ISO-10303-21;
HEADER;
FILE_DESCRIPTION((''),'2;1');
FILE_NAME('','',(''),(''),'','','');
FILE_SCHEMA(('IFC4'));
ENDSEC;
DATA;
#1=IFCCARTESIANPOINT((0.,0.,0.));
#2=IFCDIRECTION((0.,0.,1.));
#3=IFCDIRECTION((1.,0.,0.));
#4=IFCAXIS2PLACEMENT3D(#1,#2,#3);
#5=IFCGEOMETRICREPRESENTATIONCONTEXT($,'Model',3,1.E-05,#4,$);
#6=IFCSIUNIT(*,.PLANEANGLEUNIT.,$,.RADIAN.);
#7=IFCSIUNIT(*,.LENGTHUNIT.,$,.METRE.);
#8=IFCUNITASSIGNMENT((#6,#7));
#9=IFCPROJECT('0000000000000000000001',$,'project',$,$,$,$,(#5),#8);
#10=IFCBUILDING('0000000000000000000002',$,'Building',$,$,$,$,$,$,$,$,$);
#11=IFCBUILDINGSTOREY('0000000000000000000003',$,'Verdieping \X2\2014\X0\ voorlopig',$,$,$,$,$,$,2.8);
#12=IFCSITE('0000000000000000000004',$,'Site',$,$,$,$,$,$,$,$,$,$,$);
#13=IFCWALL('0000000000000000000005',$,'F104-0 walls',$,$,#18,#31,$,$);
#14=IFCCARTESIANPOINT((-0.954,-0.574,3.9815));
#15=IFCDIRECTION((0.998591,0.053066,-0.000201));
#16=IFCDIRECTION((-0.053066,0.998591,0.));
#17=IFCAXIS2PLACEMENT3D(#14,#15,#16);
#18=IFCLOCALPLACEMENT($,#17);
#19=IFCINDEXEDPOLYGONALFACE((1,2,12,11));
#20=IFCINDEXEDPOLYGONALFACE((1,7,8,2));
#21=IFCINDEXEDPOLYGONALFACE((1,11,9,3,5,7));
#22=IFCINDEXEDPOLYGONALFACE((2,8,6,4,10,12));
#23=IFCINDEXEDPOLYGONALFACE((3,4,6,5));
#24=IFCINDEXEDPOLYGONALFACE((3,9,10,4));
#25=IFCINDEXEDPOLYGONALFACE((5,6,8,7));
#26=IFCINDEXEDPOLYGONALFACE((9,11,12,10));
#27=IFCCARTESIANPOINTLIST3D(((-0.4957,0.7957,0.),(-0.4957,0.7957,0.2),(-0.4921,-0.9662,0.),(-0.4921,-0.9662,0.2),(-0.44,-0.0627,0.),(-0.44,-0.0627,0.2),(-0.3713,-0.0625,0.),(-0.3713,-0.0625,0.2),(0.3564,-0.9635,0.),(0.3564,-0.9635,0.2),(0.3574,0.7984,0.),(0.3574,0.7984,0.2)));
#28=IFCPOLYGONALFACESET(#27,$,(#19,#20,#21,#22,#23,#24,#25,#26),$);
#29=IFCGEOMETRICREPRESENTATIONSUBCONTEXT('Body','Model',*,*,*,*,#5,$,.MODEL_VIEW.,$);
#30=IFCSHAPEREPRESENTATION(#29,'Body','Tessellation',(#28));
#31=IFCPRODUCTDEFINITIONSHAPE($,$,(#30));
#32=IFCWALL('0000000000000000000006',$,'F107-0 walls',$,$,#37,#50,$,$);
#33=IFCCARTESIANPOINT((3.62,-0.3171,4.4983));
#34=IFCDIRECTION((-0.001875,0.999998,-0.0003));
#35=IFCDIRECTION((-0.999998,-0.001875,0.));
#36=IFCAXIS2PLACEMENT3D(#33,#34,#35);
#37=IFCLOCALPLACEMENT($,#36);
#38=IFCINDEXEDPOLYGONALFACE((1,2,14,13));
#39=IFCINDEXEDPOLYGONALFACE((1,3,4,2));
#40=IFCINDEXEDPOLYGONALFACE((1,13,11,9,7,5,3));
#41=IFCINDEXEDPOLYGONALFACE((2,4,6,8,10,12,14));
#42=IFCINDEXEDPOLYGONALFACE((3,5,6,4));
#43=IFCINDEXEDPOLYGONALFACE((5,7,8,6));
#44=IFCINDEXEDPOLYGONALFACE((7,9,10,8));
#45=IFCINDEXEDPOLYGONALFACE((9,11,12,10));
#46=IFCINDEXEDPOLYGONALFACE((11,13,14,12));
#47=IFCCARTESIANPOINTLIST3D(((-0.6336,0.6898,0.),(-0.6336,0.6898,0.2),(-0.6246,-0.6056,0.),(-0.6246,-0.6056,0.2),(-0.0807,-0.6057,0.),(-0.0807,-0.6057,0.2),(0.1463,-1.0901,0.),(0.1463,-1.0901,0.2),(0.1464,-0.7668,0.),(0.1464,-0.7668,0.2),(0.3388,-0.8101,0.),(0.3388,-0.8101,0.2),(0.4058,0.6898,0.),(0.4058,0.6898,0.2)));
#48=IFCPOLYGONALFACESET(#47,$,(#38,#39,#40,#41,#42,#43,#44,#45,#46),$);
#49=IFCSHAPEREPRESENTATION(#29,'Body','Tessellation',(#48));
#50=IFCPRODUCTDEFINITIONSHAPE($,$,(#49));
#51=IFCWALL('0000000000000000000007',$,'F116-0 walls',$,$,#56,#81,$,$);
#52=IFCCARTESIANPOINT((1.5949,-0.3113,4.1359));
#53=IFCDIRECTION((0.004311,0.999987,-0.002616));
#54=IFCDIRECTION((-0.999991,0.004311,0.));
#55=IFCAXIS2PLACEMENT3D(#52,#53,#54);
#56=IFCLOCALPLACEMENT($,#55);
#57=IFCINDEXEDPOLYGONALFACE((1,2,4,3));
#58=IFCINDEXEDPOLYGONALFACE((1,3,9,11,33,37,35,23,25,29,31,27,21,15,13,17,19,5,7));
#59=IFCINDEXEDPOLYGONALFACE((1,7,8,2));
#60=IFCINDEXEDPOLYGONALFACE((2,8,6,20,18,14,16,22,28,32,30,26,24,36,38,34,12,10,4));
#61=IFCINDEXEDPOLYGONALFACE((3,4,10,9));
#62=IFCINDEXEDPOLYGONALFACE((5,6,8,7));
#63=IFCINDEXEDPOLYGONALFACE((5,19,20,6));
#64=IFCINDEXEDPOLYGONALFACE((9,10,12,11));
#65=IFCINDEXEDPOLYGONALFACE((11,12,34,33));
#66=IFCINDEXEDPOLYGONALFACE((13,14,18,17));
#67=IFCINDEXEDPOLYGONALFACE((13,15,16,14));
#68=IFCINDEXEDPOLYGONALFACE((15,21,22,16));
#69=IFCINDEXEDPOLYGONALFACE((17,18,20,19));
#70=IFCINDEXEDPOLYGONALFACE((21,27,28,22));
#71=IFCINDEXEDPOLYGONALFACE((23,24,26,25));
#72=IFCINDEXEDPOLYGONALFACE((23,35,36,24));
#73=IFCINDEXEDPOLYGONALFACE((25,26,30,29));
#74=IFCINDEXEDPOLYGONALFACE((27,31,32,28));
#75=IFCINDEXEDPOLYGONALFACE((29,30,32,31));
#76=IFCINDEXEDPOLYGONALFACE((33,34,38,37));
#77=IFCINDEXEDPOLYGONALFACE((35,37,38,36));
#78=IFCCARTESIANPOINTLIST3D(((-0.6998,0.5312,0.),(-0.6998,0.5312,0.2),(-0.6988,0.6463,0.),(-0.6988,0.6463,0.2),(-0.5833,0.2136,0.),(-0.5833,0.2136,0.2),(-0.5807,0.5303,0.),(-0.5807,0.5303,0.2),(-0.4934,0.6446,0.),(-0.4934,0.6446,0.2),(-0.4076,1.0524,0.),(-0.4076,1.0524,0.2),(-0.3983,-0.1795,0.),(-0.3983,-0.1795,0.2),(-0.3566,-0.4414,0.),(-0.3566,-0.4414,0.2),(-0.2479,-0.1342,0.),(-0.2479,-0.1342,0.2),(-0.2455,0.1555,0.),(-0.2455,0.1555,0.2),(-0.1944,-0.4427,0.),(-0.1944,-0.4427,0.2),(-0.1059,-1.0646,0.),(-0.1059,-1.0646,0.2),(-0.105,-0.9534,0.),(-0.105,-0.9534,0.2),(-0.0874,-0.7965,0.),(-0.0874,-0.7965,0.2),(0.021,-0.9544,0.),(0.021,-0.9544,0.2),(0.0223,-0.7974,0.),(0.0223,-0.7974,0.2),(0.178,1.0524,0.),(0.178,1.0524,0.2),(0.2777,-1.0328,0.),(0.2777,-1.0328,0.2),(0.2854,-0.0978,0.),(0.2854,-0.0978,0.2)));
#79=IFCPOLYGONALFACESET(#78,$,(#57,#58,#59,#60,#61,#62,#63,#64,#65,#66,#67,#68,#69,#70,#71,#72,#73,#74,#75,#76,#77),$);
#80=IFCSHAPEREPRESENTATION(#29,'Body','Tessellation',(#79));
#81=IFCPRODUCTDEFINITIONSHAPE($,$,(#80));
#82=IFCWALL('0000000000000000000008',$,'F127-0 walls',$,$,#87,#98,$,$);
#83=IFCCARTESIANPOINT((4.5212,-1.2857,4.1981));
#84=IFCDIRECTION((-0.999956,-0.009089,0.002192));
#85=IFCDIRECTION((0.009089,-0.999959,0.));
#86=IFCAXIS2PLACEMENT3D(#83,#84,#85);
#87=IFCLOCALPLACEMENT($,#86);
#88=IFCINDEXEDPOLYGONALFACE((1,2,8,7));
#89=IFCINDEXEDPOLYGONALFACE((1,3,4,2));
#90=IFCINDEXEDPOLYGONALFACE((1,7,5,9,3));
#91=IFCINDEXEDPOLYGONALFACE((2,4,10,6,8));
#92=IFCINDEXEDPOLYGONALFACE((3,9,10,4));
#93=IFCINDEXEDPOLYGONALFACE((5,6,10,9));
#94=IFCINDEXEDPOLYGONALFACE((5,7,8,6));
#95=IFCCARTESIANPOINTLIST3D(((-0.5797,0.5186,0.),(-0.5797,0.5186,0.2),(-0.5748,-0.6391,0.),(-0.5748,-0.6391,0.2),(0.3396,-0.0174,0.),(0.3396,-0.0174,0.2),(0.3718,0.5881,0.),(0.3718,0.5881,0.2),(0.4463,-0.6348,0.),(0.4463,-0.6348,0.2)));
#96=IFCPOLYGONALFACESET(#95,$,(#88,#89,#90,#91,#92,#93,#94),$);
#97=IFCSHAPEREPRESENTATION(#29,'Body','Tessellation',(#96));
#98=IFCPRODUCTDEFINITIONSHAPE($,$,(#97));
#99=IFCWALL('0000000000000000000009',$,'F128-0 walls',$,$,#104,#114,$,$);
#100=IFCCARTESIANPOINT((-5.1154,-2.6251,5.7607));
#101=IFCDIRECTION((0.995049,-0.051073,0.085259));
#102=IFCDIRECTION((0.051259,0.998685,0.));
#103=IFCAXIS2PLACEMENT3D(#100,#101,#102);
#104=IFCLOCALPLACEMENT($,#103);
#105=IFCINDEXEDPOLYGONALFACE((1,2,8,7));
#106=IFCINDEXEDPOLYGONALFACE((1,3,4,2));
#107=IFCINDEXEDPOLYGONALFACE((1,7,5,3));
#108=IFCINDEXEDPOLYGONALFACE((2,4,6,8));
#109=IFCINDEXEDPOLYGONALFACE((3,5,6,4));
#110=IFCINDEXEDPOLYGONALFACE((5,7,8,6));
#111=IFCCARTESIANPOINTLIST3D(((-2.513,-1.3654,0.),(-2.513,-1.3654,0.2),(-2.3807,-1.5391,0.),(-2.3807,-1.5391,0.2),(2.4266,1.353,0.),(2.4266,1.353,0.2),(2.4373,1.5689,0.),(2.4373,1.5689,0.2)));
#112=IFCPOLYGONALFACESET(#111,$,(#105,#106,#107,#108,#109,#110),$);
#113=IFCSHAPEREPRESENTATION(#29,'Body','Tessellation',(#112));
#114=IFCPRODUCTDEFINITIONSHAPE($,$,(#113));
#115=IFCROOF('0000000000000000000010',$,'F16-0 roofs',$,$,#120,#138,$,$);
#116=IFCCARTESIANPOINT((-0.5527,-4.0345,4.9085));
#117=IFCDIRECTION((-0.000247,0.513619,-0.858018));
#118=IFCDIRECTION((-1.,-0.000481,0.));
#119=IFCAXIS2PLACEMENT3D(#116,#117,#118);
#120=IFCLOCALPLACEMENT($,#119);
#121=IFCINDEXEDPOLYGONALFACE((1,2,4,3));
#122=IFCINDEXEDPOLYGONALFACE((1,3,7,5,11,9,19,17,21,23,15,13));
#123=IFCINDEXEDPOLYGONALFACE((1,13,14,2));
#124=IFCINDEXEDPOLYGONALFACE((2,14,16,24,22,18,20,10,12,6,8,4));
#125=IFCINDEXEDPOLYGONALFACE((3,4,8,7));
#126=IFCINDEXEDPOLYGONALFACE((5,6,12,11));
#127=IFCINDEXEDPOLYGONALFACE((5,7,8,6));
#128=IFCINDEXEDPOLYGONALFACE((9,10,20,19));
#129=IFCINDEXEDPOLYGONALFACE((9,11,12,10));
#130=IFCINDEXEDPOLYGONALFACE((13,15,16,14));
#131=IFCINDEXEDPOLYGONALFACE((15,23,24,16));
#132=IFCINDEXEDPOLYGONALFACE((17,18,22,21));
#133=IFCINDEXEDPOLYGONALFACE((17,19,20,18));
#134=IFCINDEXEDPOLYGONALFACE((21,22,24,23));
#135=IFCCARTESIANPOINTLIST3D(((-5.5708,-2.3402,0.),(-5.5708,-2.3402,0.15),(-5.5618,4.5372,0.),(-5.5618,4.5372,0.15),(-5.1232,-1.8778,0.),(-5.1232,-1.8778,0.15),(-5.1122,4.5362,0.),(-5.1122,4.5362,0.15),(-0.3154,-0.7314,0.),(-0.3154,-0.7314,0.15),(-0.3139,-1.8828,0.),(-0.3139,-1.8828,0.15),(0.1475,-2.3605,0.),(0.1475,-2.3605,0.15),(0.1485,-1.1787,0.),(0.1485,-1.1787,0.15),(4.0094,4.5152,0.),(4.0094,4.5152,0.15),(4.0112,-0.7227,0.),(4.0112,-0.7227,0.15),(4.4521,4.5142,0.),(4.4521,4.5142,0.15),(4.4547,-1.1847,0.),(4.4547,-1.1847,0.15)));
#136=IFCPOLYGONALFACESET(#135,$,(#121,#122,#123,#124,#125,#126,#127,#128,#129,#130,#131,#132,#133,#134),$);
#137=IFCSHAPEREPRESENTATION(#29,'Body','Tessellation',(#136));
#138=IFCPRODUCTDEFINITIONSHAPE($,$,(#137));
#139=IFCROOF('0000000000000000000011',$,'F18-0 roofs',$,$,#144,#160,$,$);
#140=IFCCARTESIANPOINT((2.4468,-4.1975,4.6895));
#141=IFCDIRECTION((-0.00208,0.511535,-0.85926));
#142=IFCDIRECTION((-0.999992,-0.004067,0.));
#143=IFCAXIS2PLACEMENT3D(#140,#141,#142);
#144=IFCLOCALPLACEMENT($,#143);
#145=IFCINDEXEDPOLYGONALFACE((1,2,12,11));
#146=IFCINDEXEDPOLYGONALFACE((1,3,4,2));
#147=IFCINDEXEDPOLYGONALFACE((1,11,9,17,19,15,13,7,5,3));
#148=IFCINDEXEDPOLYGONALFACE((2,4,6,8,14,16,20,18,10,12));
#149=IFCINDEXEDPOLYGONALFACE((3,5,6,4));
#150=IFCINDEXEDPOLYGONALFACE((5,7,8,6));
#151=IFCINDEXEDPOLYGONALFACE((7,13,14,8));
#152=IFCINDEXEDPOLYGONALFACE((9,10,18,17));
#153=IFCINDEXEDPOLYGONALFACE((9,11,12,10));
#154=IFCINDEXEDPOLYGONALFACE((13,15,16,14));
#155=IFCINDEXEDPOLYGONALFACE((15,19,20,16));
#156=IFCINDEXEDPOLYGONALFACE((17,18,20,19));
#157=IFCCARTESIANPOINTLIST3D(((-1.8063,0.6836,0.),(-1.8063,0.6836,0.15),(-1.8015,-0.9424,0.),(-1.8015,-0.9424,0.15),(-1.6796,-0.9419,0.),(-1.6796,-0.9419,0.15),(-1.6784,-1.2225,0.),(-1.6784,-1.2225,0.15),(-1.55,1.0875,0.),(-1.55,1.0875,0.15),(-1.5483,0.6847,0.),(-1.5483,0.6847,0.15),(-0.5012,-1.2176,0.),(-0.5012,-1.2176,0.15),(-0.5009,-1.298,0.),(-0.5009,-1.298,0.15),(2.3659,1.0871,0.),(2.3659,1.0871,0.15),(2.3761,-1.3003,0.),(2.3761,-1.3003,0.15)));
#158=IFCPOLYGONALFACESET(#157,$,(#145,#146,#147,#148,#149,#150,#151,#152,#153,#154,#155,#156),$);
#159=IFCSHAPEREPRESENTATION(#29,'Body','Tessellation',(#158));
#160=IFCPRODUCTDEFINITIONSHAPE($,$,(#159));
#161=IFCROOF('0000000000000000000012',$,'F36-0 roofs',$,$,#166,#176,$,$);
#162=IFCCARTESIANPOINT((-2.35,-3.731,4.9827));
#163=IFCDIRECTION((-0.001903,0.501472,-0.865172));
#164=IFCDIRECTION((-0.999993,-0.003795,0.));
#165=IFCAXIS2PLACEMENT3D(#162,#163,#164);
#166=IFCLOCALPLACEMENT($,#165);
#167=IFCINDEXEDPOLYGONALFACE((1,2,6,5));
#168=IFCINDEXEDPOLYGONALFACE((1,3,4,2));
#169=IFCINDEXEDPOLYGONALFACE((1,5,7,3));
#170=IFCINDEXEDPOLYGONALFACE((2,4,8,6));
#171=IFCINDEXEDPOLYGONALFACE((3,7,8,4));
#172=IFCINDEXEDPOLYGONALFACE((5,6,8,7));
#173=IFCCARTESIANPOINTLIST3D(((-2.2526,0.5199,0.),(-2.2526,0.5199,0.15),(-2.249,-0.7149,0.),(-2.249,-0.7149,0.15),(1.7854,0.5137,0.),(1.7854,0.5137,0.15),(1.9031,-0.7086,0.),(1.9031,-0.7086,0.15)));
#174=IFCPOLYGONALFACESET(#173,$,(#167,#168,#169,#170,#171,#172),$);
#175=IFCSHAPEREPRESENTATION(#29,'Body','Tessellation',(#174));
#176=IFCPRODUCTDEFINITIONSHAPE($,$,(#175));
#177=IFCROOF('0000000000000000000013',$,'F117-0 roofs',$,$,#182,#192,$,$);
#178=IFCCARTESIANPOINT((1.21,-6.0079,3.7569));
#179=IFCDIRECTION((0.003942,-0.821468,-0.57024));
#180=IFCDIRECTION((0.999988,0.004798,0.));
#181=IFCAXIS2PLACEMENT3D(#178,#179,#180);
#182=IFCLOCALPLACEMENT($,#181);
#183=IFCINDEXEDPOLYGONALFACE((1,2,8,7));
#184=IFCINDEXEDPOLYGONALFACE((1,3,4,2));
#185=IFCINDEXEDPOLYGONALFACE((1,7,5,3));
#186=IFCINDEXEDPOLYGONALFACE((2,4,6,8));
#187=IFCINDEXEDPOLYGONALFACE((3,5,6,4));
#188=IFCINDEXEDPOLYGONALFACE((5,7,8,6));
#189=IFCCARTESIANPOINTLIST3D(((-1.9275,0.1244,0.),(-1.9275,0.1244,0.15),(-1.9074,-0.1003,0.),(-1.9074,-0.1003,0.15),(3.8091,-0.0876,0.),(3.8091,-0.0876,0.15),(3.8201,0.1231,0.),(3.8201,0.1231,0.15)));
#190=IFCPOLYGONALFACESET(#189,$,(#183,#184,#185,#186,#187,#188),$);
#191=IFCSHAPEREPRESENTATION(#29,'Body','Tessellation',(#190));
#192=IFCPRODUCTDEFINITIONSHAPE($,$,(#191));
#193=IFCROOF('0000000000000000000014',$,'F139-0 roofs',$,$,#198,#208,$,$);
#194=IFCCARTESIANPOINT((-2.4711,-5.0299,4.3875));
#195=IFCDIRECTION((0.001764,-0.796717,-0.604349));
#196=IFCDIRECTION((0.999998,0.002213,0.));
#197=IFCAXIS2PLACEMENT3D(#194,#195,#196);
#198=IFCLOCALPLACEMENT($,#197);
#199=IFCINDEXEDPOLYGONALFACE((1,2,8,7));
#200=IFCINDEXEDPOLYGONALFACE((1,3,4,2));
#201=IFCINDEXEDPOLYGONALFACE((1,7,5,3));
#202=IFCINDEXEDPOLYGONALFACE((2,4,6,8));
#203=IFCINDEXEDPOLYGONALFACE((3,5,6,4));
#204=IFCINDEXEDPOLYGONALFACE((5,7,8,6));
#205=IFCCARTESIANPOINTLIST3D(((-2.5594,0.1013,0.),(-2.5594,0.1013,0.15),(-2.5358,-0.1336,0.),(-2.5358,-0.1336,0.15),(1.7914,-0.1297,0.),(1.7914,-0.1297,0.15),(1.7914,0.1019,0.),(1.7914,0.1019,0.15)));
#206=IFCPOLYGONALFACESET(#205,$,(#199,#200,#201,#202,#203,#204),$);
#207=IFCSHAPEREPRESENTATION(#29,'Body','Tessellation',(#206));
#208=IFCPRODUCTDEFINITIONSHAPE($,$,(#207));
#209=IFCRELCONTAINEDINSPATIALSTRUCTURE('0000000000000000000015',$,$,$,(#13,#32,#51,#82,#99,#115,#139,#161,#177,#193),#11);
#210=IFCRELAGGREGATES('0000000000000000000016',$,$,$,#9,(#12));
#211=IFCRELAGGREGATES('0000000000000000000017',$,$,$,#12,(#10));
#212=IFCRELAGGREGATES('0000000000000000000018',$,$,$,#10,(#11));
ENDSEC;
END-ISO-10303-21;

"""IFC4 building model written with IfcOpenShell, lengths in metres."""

from ifc_helpers import new_model, si_unit, frame, origin_with_axes, place, context, subcontext, project, spatial, polyline, outline, extrude, element, save


model = new_model("IFC4")

# Units and contexts
model_context = context("Model", 3, precision=1e-05, world=origin_with_axes())
body_context = subcontext(model_context, "Body", "Model", "MODEL_VIEW")
ifc_project = project(units=[si_unit("PLANEANGLEUNIT", "RADIAN"), si_unit("LENGTHUNIT", "METRE")], contexts=[model_context])

# Site, building, storey
site = spatial("IfcSite", under=ifc_project, Name="Site")
building = spatial("IfcBuilding", under=site, Name="Building")
storey = spatial("IfcBuildingStorey", under=building, Name="Verdieping — voorlopig", Elevation=2.8)

# Walls
wall_1_placement = place(None, frame((-0.954, -0.574, 3.9815), z_axis=(0.998591, 0.053066, -0.000201), x_axis=(-0.053066, 0.998591, 0.0)))
element("IfcWall", 1, at=wall_1_placement, inside=storey, Name="F104-0 walls", context=body_context, shape_type="SweptSolid", body=[
    extrude(outline(polyline([(-0.4921, -0.9662), (0.3564, -0.9635), (0.3574, 0.7984), (-0.4957, 0.7957), (-0.3713, -0.0625), (-0.44, -0.0627), (-0.4921, -0.9662)])), origin_with_axes(), (0.0, 0.0, 1.0), 0.2),
])
wall_2_placement = place(None, frame((3.62, -0.3171, 4.4983), z_axis=(-0.001875, 0.999998, -0.0003), x_axis=(-0.999998, -0.001875, 0.0)))
element("IfcWall", 2, at=wall_2_placement, inside=storey, Name="F107-0 walls", context=body_context, shape_type="SweptSolid", body=[
    extrude(outline(polyline([(0.1463, -1.0901), (0.1464, -0.7668), (0.3388, -0.8101), (0.4058, 0.6898), (-0.6336, 0.6898), (-0.6246, -0.6056), (-0.0807, -0.6057), (0.1463, -1.0901)])), origin_with_axes(), (0.0, 0.0, 1.0), 0.2),
])
wall_3_placement = place(None, frame((1.5949, -0.3113, 4.1359), z_axis=(0.004311, 0.999987, -0.002616), x_axis=(-0.999991, 0.004311, 0.0)))
element("IfcWall", 3, at=wall_3_placement, inside=storey, Name="F116-0 walls", context=body_context, shape_type="SweptSolid", body=[
    extrude(outline(polyline([(-0.1059, -1.0646), (0.2777, -1.0328), (0.2854, -0.0978), (0.178, 1.0524), (-0.4076, 1.0524), (-0.4934, 0.6446), (-0.6988, 0.6463), (-0.6998, 0.5312), (-0.5807, 0.5303), (-0.5833, 0.2136), (-0.2455, 0.1555), (-0.2479, -0.1342), (-0.3983, -0.1795), (-0.3566, -0.4414), (-0.1944, -0.4427), (-0.0874, -0.7965), (0.0223, -0.7974), (0.021, -0.9544), (-0.105, -0.9534), (-0.1059, -1.0646)])), origin_with_axes(), (0.0, 0.0, 1.0), 0.2),
])
wall_4_placement = place(None, frame((4.5212, -1.2857, 4.1981), z_axis=(-0.999956, -0.009089, 0.002192), x_axis=(0.009089, -0.999959, 0.0)))
element("IfcWall", 4, at=wall_4_placement, inside=storey, Name="F127-0 walls", context=body_context, shape_type="SweptSolid", body=[
    extrude(outline(polyline([(-0.5748, -0.6391), (0.4463, -0.6348), (0.3396, -0.0174), (0.3718, 0.5881), (-0.5797, 0.5186), (-0.5748, -0.6391)])), origin_with_axes(), (0.0, 0.0, 1.0), 0.2),
])
wall_5_placement = place(None, frame((-5.1154, -2.6251, 5.7607), z_axis=(0.995049, -0.051073, 0.085259), x_axis=(0.051259, 0.998685, 0.0)))
element("IfcWall", 5, at=wall_5_placement, inside=storey, Name="F128-0 walls", context=body_context, shape_type="SweptSolid", body=[
    extrude(outline(polyline([(-2.3807, -1.5391), (2.4266, 1.353), (2.4373, 1.5689), (-2.513, -1.3654), (-2.3807, -1.5391)])), origin_with_axes(), (0.0, 0.0, 1.0), 0.2),
])

# Roofs
roof_1_placement = place(None, frame((-0.5527, -4.0345, 4.9085), z_axis=(-0.000247, 0.513619, -0.858018), x_axis=(-1.0, -0.000481, 0.0)))
element("IfcRoof", 6, at=roof_1_placement, inside=storey, Name="F16-0 roofs", context=body_context, shape_type="SweptSolid", body=[
    extrude(outline(polyline([(-5.5708, -2.3402), (0.1475, -2.3605), (0.1485, -1.1787), (4.4547, -1.1847), (4.4521, 4.5142), (4.0094, 4.5152), (4.0112, -0.7227), (-0.3154, -0.7314), (-0.3139, -1.8828), (-5.1232, -1.8778), (-5.1122, 4.5362), (-5.5618, 4.5372), (-5.5708, -2.3402)])), origin_with_axes(), (0.0, 0.0, 1.0), 0.15),
])
roof_2_placement = place(None, frame((2.4468, -4.1975, 4.6895), z_axis=(-0.00208, 0.511535, -0.85926), x_axis=(-0.999992, -0.004067, 0.0)))
element("IfcRoof", 7, at=roof_2_placement, inside=storey, Name="F18-0 roofs", context=body_context, shape_type="SweptSolid", body=[
    extrude(outline(polyline([(-0.5009, -1.298), (2.3761, -1.3003), (2.3659, 1.0871), (-1.55, 1.0875), (-1.5483, 0.6847), (-1.8063, 0.6836), (-1.8015, -0.9424), (-1.6796, -0.9419), (-1.6784, -1.2225), (-0.5012, -1.2176), (-0.5009, -1.298)])), origin_with_axes(), (0.0, 0.0, 1.0), 0.15),
])
roof_3_placement = place(None, frame((-2.35, -3.731, 4.9827), z_axis=(-0.001903, 0.501472, -0.865172), x_axis=(-0.999993, -0.003795, 0.0)))
element("IfcRoof", 8, at=roof_3_placement, inside=storey, Name="F36-0 roofs", context=body_context, shape_type="SweptSolid", body=[
    extrude(outline(polyline([(-2.249, -0.7149), (1.9031, -0.7086), (1.7854, 0.5137), (-2.2526, 0.5199), (-2.249, -0.7149)])), origin_with_axes(), (0.0, 0.0, 1.0), 0.15),
])
roof_4_placement = place(None, frame((1.21, -6.0079, 3.7569), z_axis=(0.003942, -0.821468, -0.57024), x_axis=(0.999988, 0.004798, 0.0)))
element("IfcRoof", 9, at=roof_4_placement, inside=storey, Name="F117-0 roofs", context=body_context, shape_type="SweptSolid", body=[
    extrude(outline(polyline([(-1.9074, -0.1003), (3.8091, -0.0876), (3.8201, 0.1231), (-1.9275, 0.1244), (-1.9074, -0.1003)])), origin_with_axes(), (0.0, 0.0, 1.0), 0.15),
])
roof_5_placement = place(None, frame((-2.4711, -5.0299, 4.3875), z_axis=(0.001764, -0.796717, -0.604349), x_axis=(0.999998, 0.002213, 0.0)))
element("IfcRoof", 10, at=roof_5_placement, inside=storey, Name="F139-0 roofs", context=body_context, shape_type="SweptSolid", body=[
    extrude(outline(polyline([(-2.5358, -0.1336), (1.7914, -0.1297), (1.7914, 0.1019), (-2.5594, 0.1013), (-2.5358, -0.1336)])), origin_with_axes(), (0.0, 0.0, 1.0), 0.15),
])

save(model, "model.ifc")
